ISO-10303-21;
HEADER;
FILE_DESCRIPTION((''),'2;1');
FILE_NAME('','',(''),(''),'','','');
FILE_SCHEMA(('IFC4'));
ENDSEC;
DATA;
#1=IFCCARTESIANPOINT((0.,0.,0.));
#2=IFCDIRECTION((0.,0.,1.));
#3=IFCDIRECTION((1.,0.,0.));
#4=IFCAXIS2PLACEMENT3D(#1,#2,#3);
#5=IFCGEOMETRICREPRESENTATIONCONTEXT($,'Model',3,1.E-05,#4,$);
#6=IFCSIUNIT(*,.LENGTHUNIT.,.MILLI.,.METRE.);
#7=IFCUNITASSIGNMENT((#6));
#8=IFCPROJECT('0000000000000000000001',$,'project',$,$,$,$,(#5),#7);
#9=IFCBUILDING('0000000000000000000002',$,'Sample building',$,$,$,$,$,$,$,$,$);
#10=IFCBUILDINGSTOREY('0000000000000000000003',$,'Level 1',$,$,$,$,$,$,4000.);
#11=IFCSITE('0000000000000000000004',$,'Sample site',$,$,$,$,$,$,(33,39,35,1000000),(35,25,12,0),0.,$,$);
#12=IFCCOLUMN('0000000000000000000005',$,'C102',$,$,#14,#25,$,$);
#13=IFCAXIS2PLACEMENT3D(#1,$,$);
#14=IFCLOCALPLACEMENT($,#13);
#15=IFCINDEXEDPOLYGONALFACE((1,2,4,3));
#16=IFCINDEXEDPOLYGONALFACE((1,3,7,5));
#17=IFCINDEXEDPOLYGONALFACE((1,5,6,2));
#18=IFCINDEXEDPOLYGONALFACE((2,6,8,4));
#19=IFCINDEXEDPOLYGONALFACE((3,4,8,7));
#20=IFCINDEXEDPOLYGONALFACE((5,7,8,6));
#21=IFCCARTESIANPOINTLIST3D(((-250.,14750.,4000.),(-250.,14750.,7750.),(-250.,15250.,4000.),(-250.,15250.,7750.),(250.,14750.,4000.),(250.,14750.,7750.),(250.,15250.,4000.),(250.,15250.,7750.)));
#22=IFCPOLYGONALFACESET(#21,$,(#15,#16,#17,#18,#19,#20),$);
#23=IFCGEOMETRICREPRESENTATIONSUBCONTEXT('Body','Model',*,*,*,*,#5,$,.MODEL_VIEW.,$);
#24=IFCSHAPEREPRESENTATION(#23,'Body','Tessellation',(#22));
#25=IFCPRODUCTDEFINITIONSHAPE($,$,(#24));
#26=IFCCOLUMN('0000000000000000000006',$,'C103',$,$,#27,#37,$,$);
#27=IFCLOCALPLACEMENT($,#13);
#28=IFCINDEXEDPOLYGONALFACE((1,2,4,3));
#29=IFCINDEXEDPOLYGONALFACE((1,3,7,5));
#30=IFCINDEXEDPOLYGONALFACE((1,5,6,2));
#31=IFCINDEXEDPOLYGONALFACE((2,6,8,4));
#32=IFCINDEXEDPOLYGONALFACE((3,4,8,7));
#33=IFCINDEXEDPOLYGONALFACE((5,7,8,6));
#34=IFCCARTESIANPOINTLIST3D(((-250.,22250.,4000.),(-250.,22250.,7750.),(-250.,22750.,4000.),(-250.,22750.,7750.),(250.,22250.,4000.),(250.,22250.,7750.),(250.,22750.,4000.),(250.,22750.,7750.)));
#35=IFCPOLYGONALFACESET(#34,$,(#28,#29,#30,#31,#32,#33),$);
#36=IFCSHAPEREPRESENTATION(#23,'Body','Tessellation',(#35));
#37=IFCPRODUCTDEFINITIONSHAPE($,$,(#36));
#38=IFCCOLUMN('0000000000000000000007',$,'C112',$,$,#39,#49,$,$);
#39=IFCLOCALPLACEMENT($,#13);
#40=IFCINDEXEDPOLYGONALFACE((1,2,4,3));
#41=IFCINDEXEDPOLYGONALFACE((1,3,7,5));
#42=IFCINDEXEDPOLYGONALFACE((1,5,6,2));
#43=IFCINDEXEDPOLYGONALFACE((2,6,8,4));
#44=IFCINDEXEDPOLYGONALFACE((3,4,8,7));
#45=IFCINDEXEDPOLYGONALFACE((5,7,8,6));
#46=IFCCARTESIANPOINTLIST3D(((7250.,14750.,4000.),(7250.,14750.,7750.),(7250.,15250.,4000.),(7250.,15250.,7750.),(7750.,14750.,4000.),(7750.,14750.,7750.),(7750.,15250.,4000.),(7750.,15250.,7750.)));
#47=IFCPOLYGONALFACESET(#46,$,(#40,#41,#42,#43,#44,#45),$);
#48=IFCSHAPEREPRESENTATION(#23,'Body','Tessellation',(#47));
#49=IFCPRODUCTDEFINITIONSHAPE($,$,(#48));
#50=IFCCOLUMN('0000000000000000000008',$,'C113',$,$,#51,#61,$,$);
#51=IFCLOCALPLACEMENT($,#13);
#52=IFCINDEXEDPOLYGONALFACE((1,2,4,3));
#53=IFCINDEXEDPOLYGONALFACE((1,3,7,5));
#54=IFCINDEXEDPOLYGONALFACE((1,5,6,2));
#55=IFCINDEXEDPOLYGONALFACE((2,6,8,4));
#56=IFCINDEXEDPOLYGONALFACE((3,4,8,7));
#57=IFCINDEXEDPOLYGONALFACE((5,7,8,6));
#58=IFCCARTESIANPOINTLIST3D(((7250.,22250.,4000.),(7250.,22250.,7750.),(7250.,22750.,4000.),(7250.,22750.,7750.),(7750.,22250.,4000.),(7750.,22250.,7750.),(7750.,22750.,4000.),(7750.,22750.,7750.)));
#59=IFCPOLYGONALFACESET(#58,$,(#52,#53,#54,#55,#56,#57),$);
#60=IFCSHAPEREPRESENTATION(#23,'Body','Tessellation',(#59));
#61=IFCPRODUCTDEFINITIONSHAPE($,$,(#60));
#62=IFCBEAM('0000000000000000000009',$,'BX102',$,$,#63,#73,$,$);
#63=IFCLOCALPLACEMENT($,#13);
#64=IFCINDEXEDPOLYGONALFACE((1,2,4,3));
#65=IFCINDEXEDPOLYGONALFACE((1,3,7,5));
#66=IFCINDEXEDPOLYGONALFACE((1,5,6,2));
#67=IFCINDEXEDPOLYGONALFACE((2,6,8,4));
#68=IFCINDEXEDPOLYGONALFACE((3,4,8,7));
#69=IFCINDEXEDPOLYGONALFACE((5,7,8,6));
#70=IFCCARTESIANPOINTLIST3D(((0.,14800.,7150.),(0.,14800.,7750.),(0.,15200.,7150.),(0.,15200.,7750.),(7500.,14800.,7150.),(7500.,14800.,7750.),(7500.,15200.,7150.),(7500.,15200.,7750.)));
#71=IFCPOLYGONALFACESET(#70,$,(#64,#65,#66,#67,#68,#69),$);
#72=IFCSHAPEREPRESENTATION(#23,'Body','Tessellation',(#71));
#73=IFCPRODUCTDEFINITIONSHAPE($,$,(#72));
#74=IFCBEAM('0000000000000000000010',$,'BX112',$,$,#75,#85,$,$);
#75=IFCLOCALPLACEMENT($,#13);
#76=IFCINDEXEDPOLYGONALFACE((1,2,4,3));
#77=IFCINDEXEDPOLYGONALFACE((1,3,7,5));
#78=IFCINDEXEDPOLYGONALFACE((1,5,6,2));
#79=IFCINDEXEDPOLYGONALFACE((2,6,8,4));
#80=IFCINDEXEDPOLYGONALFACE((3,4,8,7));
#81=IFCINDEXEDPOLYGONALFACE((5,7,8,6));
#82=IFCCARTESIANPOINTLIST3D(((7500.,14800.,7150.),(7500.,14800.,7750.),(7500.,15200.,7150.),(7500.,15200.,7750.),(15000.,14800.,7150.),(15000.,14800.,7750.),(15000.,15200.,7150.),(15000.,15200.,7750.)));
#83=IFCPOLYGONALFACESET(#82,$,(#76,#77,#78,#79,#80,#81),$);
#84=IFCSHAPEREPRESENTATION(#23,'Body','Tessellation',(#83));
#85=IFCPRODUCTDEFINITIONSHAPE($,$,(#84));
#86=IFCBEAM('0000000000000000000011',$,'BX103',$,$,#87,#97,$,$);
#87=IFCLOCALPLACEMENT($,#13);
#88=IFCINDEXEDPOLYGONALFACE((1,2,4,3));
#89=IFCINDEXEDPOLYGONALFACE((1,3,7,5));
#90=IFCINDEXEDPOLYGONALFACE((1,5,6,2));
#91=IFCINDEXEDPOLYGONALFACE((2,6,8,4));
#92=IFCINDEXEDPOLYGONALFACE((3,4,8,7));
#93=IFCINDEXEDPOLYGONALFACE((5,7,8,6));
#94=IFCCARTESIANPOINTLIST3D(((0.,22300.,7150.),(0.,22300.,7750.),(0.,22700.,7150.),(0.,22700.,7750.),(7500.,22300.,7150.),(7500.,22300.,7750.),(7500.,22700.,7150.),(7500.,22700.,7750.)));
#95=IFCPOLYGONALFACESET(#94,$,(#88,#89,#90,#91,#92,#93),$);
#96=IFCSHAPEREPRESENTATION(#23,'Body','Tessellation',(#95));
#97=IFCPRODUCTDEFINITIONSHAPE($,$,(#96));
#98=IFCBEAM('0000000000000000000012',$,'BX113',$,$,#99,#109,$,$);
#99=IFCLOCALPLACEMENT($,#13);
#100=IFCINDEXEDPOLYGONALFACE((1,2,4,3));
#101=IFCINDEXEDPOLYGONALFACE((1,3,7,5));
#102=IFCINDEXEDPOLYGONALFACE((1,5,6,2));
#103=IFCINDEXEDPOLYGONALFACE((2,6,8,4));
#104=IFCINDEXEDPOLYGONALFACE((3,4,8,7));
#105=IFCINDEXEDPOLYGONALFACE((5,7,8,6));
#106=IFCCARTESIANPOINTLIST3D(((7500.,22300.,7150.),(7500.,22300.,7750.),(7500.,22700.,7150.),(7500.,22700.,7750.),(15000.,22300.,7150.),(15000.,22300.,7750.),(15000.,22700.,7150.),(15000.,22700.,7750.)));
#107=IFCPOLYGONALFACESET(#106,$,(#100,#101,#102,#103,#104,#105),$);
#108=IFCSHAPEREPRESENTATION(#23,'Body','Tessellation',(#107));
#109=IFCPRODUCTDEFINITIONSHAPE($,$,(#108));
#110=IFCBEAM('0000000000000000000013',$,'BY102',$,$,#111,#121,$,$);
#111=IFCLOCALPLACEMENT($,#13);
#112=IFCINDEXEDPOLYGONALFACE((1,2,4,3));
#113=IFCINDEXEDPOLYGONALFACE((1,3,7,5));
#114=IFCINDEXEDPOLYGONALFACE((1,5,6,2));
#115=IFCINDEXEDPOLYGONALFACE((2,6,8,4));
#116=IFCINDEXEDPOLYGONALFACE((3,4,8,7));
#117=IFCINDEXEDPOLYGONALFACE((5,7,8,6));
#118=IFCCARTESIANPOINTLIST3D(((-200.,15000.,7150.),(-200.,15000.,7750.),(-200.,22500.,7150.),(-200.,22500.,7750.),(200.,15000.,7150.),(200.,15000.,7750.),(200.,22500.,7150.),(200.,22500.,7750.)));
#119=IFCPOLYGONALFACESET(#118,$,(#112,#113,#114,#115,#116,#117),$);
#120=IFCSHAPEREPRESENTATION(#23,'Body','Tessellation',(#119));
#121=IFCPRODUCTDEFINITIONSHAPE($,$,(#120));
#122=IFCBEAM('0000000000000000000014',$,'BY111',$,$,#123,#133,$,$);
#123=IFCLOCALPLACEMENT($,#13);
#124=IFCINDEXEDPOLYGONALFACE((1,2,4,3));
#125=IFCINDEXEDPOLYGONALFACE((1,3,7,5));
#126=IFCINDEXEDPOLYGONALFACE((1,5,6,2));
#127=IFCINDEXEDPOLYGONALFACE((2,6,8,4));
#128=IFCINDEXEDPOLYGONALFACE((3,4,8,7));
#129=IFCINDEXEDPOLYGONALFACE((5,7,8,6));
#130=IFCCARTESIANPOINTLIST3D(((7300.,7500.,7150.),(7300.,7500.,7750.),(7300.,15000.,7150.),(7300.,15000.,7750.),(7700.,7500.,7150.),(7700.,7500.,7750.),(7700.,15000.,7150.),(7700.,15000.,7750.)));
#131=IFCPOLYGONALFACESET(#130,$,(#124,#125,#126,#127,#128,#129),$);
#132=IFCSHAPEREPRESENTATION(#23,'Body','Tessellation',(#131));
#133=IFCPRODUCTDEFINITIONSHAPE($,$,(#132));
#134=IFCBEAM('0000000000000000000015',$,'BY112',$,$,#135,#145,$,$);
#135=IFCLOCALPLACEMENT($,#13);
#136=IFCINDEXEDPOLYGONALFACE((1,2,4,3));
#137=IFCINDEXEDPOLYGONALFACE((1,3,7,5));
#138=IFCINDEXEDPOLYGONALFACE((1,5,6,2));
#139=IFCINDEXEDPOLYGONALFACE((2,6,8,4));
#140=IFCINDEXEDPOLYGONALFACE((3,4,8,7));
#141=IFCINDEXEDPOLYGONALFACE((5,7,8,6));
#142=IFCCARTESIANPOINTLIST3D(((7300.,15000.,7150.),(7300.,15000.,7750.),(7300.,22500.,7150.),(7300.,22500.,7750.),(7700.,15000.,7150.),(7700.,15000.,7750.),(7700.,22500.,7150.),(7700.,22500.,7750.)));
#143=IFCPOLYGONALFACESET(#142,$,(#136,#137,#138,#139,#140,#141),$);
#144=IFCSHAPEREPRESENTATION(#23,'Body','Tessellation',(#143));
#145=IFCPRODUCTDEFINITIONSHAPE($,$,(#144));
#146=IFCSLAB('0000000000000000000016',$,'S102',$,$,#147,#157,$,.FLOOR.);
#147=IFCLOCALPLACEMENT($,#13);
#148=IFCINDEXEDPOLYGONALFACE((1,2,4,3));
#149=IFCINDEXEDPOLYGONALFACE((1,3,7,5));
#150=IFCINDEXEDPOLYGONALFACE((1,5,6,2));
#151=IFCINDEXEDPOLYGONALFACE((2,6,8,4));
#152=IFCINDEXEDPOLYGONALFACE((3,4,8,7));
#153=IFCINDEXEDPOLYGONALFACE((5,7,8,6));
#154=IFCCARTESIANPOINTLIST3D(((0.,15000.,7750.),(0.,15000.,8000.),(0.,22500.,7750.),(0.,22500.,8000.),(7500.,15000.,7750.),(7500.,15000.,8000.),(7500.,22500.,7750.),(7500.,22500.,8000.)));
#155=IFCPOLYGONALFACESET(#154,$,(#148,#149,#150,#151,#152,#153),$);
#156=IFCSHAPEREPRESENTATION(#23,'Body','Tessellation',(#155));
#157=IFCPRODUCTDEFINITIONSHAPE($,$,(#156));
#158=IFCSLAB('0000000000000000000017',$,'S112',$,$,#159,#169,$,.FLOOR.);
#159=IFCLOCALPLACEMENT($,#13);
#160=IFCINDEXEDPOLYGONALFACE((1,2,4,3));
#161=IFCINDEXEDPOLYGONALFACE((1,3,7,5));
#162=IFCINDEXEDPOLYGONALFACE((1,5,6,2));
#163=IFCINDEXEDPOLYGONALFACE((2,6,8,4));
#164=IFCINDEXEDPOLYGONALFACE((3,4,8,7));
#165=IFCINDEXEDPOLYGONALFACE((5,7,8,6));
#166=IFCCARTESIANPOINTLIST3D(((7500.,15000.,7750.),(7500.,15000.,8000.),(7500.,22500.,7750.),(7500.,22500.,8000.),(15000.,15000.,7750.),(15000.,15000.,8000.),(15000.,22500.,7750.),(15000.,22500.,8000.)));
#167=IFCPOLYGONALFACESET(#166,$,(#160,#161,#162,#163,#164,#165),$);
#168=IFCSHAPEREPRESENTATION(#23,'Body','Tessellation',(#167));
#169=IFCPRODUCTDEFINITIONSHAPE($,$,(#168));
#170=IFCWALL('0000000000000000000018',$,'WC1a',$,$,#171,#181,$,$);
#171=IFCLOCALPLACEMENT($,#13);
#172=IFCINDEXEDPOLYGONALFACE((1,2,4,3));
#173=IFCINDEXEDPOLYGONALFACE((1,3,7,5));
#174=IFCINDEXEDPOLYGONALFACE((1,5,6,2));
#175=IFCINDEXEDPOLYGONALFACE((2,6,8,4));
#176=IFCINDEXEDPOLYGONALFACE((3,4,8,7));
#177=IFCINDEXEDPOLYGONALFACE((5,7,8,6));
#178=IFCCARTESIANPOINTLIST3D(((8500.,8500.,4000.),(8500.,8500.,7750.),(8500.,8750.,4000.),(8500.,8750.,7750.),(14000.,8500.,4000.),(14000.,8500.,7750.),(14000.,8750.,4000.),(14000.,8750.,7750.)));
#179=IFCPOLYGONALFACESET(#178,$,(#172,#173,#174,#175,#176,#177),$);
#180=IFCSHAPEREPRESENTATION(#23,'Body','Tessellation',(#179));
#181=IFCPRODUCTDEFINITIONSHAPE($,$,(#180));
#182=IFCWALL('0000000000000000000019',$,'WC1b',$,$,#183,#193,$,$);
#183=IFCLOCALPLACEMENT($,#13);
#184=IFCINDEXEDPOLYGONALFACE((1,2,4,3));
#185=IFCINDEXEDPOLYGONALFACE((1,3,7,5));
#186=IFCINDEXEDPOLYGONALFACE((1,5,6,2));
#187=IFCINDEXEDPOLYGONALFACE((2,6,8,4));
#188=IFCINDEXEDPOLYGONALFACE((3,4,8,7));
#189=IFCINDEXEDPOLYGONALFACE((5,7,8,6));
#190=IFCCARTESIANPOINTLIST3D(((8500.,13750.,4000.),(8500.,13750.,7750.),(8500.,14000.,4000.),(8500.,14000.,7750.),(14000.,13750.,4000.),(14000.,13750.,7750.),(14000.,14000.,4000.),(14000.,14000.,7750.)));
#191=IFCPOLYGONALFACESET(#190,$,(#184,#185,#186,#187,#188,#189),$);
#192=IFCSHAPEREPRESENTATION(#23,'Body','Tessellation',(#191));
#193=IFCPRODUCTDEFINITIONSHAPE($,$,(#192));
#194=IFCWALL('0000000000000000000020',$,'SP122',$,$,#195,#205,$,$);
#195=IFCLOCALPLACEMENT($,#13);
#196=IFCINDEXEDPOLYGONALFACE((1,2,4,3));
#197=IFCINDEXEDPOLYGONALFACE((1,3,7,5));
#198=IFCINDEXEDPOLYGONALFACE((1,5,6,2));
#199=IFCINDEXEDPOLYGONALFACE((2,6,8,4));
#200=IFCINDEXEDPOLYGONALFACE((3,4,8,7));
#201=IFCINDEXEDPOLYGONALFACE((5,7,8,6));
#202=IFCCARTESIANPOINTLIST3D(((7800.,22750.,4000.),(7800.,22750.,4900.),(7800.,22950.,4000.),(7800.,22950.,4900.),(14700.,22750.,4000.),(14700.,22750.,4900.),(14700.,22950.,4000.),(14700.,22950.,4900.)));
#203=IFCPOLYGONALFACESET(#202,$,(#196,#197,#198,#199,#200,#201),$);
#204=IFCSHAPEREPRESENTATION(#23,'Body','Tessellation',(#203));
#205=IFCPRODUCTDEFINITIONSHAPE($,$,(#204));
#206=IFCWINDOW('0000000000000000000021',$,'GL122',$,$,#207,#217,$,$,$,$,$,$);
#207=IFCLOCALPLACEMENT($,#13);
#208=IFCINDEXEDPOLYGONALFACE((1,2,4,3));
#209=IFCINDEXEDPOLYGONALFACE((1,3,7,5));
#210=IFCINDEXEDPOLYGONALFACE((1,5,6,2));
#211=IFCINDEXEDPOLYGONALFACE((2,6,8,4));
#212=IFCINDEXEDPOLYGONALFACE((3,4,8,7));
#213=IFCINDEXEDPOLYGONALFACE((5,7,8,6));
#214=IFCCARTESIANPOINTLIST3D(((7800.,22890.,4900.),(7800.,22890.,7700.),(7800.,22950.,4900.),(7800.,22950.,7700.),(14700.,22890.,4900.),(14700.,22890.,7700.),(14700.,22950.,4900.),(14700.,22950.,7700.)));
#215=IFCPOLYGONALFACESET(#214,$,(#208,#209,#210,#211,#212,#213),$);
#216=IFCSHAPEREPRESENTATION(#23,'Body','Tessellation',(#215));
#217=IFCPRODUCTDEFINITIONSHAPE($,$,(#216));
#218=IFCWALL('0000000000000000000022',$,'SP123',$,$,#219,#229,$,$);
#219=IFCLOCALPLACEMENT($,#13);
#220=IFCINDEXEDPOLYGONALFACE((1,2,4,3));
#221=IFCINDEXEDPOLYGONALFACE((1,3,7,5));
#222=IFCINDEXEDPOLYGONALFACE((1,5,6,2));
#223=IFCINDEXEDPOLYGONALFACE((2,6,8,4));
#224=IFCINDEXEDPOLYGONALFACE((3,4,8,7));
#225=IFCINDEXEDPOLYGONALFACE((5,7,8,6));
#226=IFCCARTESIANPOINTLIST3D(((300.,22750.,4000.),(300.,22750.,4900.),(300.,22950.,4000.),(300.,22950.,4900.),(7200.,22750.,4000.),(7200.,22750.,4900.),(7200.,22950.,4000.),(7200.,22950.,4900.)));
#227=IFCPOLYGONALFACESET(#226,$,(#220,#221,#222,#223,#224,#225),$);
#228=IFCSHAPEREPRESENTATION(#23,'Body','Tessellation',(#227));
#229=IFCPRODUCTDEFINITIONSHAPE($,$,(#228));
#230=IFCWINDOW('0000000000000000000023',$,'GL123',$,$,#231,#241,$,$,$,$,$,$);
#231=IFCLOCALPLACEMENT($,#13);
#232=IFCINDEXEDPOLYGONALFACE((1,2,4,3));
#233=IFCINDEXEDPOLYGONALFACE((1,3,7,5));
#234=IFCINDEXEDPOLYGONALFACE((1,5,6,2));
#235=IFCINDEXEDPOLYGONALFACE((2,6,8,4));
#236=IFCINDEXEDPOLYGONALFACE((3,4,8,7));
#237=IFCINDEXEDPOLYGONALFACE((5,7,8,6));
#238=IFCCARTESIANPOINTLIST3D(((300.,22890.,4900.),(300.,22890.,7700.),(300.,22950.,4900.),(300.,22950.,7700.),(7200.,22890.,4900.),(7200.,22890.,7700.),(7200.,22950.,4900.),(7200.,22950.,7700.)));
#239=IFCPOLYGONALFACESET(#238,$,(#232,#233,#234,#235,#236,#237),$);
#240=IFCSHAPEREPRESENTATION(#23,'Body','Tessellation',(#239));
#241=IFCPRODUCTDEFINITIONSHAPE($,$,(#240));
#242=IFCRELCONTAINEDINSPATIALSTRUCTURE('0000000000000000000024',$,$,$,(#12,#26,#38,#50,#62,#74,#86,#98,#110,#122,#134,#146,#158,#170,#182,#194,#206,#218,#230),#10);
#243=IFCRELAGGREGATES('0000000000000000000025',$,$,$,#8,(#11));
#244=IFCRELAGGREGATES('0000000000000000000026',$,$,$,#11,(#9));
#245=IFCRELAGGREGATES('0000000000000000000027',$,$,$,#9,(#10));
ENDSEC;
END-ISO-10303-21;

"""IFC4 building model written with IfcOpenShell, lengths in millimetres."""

from ifc_helpers import new_model, si_unit, frame, origin_with_axes, place, context, subcontext, project, spatial, indexed_curve, outline, extrude, element, save


model = new_model("IFC4")

# Units and contexts
model_context = context("Model", 3, precision=1e-05, world=origin_with_axes())
body_context = subcontext(model_context, "Body", "Model", "MODEL_VIEW")
ifc_project = project(units=[si_unit("LENGTHUNIT", "METRE", prefix="MILLI")], contexts=[model_context])

# Site, building, storey
site = spatial("IfcSite", under=ifc_project, Name="Sample site", RefLatitude=(33, 39, 35, 1000000), RefLongitude=(35, 25, 12, 0), RefElevation=0.0)
building = spatial("IfcBuilding", under=site, Name="Sample building")
storey = spatial("IfcBuildingStorey", under=building, Name="Level 1", Elevation=4000.0)

# Columns
for number, where, z_axis, x_axis, name in (
    (1, (-250.0, 14750.0, 4000.0), (0.0, 0.0, 1.0), (1.0, 0.0, 0.0), "C102"),
    (2, (-250.0, 22250.0, 4000.0), (0.0, 0.0, 1.0), (1.0, 0.0, 0.0), "C103"),
    (3, (7250.0, 14750.0, 4000.0), (0.0, 0.0, 1.0), (1.0, 0.0, 0.0), "C112"),
    (4, (7250.0, 22250.0, 4000.0), (0.0, 0.0, 1.0), (1.0, 0.0, 0.0), "C113"),
):
    element("IfcColumn", number, at=place(None, frame(where, z_axis=z_axis, x_axis=x_axis)), inside=storey, Name=name, context=body_context, shape_type="SweptSolid", body=[
        extrude(outline(indexed_curve([(0.0, 0.0), (0.0, 500.0), (500.0, 500.0), (500.0, 0.0), (0.0, 0.0)], self_intersect=False)), origin_with_axes(), (0.0, 0.0, 1.0), 3750.0),
    ])

# Beams
for number, where, z_axis, x_axis, name in (
    (5, (0.0, 14800.0, 7150.0), (0.0, 0.0, 1.0), (1.0, 0.0, 0.0), "BX102"),
    (6, (7500.0, 14800.0, 7150.0), (0.0, 0.0, 1.0), (1.0, 0.0, 0.0), "BX112"),
    (7, (0.0, 22300.0, 7150.0), (0.0, 0.0, 1.0), (1.0, 0.0, 0.0), "BX103"),
    (8, (7500.0, 22300.0, 7150.0), (0.0, 0.0, 1.0), (1.0, 0.0, 0.0), "BX113"),
    (9, (200.0, 15000.0, 7150.0), (0.0, 0.0, 1.0), (0.0, 1.0, 0.0), "BY102"),
    (10, (7700.0, 7500.0, 7150.0), (0.0, 0.0, 1.0), (0.0, 1.0, 0.0), "BY111"),
    (11, (7700.0, 15000.0, 7150.0), (0.0, 0.0, 1.0), (0.0, 1.0, 0.0), "BY112"),
):
    element("IfcBeam", number, at=place(None, frame(where, z_axis=z_axis, x_axis=x_axis)), inside=storey, Name=name, context=body_context, shape_type="SweptSolid", body=[
        extrude(outline(indexed_curve([(0.0, 0.0), (0.0, 400.0), (7500.0, 400.0), (7500.0, 0.0), (0.0, 0.0)], self_intersect=False)), origin_with_axes(), (0.0, 0.0, 1.0), 600.0),
    ])

# Slabs
for number, where, z_axis, x_axis, name in (
    (12, (0.0, 15000.0, 7750.0), (0.0, 0.0, 1.0), (1.0, 0.0, 0.0), "S102"),
    (13, (7500.0, 15000.0, 7750.0), (0.0, 0.0, 1.0), (1.0, 0.0, 0.0), "S112"),
):
    element("IfcSlab", number, at=place(None, frame(where, z_axis=z_axis, x_axis=x_axis)), inside=storey, Name=name, PredefinedType="FLOOR", context=body_context, shape_type="SweptSolid", body=[
        extrude(outline(indexed_curve([(0.0, 0.0), (0.0, 7500.0), (7500.0, 7500.0), (7500.0, 0.0), (0.0, 0.0)], self_intersect=False)), origin_with_axes(), (0.0, 0.0, 1.0), 250.0),
    ])

# Walls
for number, where, z_axis, x_axis, name in (
    (14, (8500.0, 8500.0, 4000.0), (0.0, 0.0, 1.0), (1.0, 0.0, 0.0), "WC1a"),
    (15, (8500.0, 13750.0, 4000.0), (0.0, 0.0, 1.0), (1.0, 0.0, 0.0), "WC1b"),
):
    element("IfcWall", number, at=place(None, frame(where, z_axis=z_axis, x_axis=x_axis)), inside=storey, Name=name, context=body_context, shape_type="SweptSolid", body=[
        extrude(outline(indexed_curve([(0.0, 0.0), (0.0, 250.0), (5500.0, 250.0), (5500.0, 0.0), (0.0, 0.0)], self_intersect=False)), origin_with_axes(), (0.0, 0.0, 1.0), 3750.0),
    ])
wall_1_placement = place(None, frame((14700.0, 22950.0, 4000.0), z_axis=(0.0, 0.0, 1.0), x_axis=(-1.0, 0.0, 0.0)))
element("IfcWall", 16, at=wall_1_placement, inside=storey, Name="SP122", context=body_context, shape_type="SweptSolid", body=[
    extrude(outline(indexed_curve([(0.0, 0.0), (0.0, 200.0), (6900.0, 200.0), (6900.0, 0.0), (0.0, 0.0)], self_intersect=False)), origin_with_axes(), (0.0, 0.0, 1.0), 900.0),
])

# Window
window_1_placement = place(None, frame((14700.0, 22950.0, 4900.0), z_axis=(0.0, 0.0, 1.0), x_axis=(-1.0, 0.0, 0.0)))
element("IfcWindow", 17, at=window_1_placement, inside=storey, Name="GL122", context=body_context, shape_type="SweptSolid", body=[
    extrude(outline(indexed_curve([(0.0, 0.0), (0.0, 60.0), (6900.0, 60.0), (6900.0, 0.0), (0.0, 0.0)], self_intersect=False)), origin_with_axes(), (0.0, 0.0, 1.0), 2800.0),
])

# Wall
wall_2_placement = place(None, frame((7200.0, 22950.0, 4000.0), z_axis=(0.0, 0.0, 1.0), x_axis=(-1.0, 0.0, 0.0)))
element("IfcWall", 18, at=wall_2_placement, inside=storey, Name="SP123", context=body_context, shape_type="SweptSolid", body=[
    extrude(outline(indexed_curve([(0.0, 0.0), (0.0, 200.0), (6900.0, 200.0), (6900.0, 0.0), (0.0, 0.0)], self_intersect=False)), origin_with_axes(), (0.0, 0.0, 1.0), 900.0),
])

# Window
window_2_placement = place(None, frame((7200.0, 22950.0, 4900.0), z_axis=(0.0, 0.0, 1.0), x_axis=(-1.0, 0.0, 0.0)))
element("IfcWindow", 19, at=window_2_placement, inside=storey, Name="GL123", context=body_context, shape_type="SweptSolid", body=[
    extrude(outline(indexed_curve([(0.0, 0.0), (0.0, 60.0), (6900.0, 60.0), (6900.0, 0.0), (0.0, 0.0)], self_intersect=False)), origin_with_axes(), (0.0, 0.0, 1.0), 2800.0),
])

save(model, "model.ifc")
